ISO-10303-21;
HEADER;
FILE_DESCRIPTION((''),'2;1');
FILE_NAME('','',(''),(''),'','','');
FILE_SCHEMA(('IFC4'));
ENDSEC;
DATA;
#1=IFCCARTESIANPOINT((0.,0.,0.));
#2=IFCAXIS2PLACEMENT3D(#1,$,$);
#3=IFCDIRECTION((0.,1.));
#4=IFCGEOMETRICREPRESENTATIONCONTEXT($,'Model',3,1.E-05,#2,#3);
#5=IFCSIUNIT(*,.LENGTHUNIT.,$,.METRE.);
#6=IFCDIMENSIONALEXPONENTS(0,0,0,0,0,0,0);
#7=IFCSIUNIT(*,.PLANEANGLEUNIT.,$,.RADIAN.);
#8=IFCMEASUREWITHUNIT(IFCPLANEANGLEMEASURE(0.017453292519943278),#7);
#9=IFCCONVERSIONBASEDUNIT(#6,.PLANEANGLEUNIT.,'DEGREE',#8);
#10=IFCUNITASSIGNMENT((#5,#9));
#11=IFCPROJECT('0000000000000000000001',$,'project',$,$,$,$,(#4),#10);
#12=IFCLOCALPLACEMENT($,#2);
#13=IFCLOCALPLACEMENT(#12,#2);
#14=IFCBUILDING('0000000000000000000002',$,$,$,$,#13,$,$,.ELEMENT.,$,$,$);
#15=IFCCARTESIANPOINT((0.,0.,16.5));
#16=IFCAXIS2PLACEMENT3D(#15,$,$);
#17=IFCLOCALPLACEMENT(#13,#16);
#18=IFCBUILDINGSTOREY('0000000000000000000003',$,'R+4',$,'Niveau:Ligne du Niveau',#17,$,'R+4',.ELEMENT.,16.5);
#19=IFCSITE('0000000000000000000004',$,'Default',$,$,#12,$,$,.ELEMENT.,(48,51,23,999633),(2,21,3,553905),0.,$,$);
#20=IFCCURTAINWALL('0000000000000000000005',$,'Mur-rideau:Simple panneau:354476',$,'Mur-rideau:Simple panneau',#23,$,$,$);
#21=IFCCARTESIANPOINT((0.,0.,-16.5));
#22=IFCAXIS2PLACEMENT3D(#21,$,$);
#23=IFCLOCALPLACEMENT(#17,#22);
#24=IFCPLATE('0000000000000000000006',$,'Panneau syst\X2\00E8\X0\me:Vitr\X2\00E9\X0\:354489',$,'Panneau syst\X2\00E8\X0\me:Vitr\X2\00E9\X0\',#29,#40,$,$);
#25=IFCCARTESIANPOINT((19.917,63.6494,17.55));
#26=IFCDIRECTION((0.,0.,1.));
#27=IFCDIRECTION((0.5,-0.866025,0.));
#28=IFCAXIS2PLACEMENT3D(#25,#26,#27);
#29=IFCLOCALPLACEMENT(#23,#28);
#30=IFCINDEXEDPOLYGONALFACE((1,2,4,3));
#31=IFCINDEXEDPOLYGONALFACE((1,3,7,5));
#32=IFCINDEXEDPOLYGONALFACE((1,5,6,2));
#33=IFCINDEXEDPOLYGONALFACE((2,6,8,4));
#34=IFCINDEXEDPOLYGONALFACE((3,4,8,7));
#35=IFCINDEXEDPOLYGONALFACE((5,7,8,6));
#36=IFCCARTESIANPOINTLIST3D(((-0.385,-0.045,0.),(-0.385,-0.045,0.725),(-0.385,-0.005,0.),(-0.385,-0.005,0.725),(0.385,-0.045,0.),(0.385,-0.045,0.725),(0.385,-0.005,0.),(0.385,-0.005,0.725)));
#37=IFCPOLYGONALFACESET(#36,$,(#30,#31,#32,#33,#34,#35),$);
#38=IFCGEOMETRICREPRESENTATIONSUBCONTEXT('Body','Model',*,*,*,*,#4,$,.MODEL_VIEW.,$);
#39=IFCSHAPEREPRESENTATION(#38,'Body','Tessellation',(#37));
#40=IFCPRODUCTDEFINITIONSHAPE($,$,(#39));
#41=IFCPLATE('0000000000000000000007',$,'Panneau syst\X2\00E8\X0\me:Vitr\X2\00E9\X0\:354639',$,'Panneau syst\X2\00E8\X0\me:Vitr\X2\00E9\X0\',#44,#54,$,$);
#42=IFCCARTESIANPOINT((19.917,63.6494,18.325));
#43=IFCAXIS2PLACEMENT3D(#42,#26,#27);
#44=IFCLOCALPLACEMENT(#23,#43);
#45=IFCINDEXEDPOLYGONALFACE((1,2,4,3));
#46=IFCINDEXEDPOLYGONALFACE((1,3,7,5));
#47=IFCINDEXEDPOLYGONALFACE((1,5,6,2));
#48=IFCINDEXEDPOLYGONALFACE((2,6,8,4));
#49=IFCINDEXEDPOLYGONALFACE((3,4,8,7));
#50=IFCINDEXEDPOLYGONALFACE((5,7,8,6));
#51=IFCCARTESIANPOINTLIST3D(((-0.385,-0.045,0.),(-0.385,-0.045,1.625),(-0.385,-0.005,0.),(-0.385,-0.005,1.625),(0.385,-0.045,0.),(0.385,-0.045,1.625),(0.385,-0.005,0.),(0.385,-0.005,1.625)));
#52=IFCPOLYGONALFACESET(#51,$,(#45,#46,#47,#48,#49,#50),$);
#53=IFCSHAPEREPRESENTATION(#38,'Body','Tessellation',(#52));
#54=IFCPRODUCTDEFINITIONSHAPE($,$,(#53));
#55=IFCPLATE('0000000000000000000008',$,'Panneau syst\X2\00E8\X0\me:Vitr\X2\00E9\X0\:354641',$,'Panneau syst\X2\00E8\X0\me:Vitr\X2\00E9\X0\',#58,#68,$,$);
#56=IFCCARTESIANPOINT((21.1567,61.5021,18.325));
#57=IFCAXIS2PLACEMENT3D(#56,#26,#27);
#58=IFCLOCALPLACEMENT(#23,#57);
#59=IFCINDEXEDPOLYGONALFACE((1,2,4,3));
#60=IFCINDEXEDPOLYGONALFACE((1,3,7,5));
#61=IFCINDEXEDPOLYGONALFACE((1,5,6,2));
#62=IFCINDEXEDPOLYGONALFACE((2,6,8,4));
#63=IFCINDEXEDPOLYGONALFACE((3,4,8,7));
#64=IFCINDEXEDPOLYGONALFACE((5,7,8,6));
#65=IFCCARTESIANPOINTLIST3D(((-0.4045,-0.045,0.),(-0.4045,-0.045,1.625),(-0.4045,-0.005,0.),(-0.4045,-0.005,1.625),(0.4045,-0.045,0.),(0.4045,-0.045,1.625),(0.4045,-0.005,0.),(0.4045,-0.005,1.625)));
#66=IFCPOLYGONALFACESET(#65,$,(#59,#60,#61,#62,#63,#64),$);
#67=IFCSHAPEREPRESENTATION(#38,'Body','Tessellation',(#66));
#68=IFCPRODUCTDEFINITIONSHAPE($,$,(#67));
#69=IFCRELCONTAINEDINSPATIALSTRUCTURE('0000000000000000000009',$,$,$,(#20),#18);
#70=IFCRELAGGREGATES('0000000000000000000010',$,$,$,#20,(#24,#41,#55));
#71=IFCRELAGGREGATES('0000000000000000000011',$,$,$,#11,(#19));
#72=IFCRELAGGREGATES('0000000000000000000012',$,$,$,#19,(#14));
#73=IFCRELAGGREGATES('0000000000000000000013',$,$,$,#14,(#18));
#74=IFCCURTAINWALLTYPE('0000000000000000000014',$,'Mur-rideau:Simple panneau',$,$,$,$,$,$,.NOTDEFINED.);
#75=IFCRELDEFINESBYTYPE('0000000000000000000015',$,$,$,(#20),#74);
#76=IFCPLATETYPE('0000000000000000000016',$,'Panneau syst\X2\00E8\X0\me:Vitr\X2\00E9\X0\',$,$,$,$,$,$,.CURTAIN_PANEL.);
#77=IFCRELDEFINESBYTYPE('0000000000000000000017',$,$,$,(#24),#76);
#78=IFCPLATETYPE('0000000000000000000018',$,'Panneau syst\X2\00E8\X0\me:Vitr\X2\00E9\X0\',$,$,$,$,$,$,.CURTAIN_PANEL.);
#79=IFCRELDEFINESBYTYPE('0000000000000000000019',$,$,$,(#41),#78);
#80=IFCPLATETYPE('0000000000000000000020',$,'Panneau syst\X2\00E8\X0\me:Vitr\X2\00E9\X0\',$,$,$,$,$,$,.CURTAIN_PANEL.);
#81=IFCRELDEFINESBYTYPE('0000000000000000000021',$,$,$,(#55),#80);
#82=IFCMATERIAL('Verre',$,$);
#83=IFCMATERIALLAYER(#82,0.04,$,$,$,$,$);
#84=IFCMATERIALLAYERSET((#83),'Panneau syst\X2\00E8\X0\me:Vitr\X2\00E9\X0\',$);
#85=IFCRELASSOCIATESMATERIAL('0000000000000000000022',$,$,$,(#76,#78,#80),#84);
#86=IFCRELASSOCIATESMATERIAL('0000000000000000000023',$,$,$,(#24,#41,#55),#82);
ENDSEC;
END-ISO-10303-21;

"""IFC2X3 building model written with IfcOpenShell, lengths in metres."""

from ifc_helpers import new_model, entity, si_unit, converted_unit, direction, frame, frame_2d, origin, place, context, subcontext, project, spatial, rectangle, extrude, source, transform, mapped, material, layer, layer_set, type_object, type_shapes, element, aggregate, save


model = new_model("IFC2X3")

# Units and contexts
model_context = context("Model", 3, precision=1e-05, world=origin(), true_north=direction((0.0, 1.0)))
body_context = subcontext(model_context, "Body", "Model", "MODEL_VIEW")
ifc_project = project(units=[si_unit("LENGTHUNIT", "METRE"), converted_unit("PLANEANGLEUNIT", "DEGREE", entity("IfcPlaneAngleMeasure", 0.017453292519943278), si_unit("PLANEANGLEUNIT", "RADIAN"), dimensions=[0, 0, 0, 0, 0, 0, 0])], contexts=[model_context])

# Site, building, storey
site_placement = place(None, origin())
site = spatial("IfcSite", under=ifc_project, at=site_placement, Name="Default", CompositionType="ELEMENT", RefLatitude=(48, 51, 23, 999633), RefLongitude=(2, 21, 3, 553905), RefElevation=0.0)
building_placement = place(site_placement, origin())
building = spatial("IfcBuilding", under=site, at=building_placement, CompositionType="ELEMENT")
storey_placement = place(building_placement, frame((0.0, 0.0, 16.5)))
storey = spatial("IfcBuildingStorey", under=building, at=storey_placement, Name="R+4", ObjectType="Niveau:Ligne du Niveau", LongName="R+4", CompositionType="ELEMENT", Elevation=16.5)

# Shared definitions
curtain_wall_type = type_object("IfcCurtainWallType", Name="Mur-rideau:Simple panneau", PredefinedType="NOTDEFINED")

# Curtain wall, plates
curtain_wall_1_placement = place(storey_placement, frame((0.0, 0.0, -16.5)))
curtain_wall_1 = element("IfcCurtainWall", 1, at=curtain_wall_1_placement, inside=storey, type_object=curtain_wall_type, Name="Mur-rideau:Simple panneau:354476", ObjectType="Mur-rideau:Simple panneau")
ifc_material_1 = material(Name="Verre")
ifc_layer_1 = layer(ifc_material_1, 0.04)
ifc_layer_set_1 = layer_set([ifc_layer_1], Name="Panneau système:Vitré")
plate_type_1 = type_object("IfcPlateType", Name="Panneau système:Vitré", PredefinedType="CURTAIN_PANEL", material=ifc_layer_set_1)
shared_shape_1 = source(origin(), body_context, "Body", "SweptSolid", [
    extrude(rectangle(XDim=0.04, YDim=0.77, at=frame_2d((0.0, 0.0), x_axis=(1.0, 0.0))), frame((0.0, -0.025, 0.0), z_axis=(0.0, 0.0, 1.0), x_axis=(0.0, 1.0, 0.0)), (0.0, 0.0, 1.0), 0.725),
])
type_shapes(plate_type_1, [shared_shape_1])
plate_1_placement = place(curtain_wall_1_placement, frame((19.917, 63.6494, 17.55), z_axis=(0.0, 0.0, 1.0), x_axis=(0.5, -0.866025, 0.0)))
plate_1 = element("IfcPlate", 2, at=plate_1_placement, type_object=plate_type_1, material=ifc_material_1, Name="Panneau système:Vitré:354489", ObjectType="Panneau système:Vitré", context=body_context, shape_type="MappedRepresentation", body=[
    mapped(shared_shape_1, transform((0.0, 0.0, 0.0), scale=1.0)),
])
plate_type_2 = type_object("IfcPlateType", Name="Panneau système:Vitré", PredefinedType="CURTAIN_PANEL", material=ifc_layer_set_1)
shared_shape_2 = source(origin(), body_context, "Body", "SweptSolid", [
    extrude(rectangle(XDim=0.04, YDim=0.77, at=frame_2d((0.0, 0.0), x_axis=(1.0, 0.0))), frame((0.0, -0.025, 0.0), z_axis=(0.0, 0.0, 1.0), x_axis=(0.0, 1.0, 0.0)), (0.0, 0.0, 1.0), 1.625),
])
type_shapes(plate_type_2, [shared_shape_2])
plate_2_placement = place(curtain_wall_1_placement, frame((19.917, 63.6494, 18.325), z_axis=(0.0, 0.0, 1.0), x_axis=(0.5, -0.866025, 0.0)))
plate_2 = element("IfcPlate", 3, at=plate_2_placement, type_object=plate_type_2, material=ifc_material_1, Name="Panneau système:Vitré:354639", ObjectType="Panneau système:Vitré", context=body_context, shape_type="MappedRepresentation", body=[
    mapped(shared_shape_2, transform((0.0, 0.0, 0.0), scale=1.0)),
])
plate_type_3 = type_object("IfcPlateType", Name="Panneau système:Vitré", PredefinedType="CURTAIN_PANEL", material=ifc_layer_set_1)
shared_shape_3 = source(origin(), body_context, "Body", "SweptSolid", [
    extrude(rectangle(XDim=0.04, YDim=0.8089, at=frame_2d((0.0, 0.0), x_axis=(1.0, 0.0))), frame((0.0, -0.025, 0.0), z_axis=(0.0, 0.0, 1.0), x_axis=(0.0, 1.0, 0.0)), (0.0, 0.0, 1.0), 1.625),
])
type_shapes(plate_type_3, [shared_shape_3])
plate_3_placement = place(curtain_wall_1_placement, frame((21.1567, 61.5021, 18.325), z_axis=(0.0, 0.0, 1.0), x_axis=(0.5, -0.866025, 0.0)))
plate_3 = element("IfcPlate", 4, at=plate_3_placement, type_object=plate_type_3, material=ifc_material_1, Name="Panneau système:Vitré:354641", ObjectType="Panneau système:Vitré", context=body_context, shape_type="MappedRepresentation", body=[
    mapped(shared_shape_3, transform((0.0, 0.0, 0.0), scale=1.0)),
])
aggregate(curtain_wall_1, [plate_1, plate_2, plate_3])

save(model, "model.ifc")
